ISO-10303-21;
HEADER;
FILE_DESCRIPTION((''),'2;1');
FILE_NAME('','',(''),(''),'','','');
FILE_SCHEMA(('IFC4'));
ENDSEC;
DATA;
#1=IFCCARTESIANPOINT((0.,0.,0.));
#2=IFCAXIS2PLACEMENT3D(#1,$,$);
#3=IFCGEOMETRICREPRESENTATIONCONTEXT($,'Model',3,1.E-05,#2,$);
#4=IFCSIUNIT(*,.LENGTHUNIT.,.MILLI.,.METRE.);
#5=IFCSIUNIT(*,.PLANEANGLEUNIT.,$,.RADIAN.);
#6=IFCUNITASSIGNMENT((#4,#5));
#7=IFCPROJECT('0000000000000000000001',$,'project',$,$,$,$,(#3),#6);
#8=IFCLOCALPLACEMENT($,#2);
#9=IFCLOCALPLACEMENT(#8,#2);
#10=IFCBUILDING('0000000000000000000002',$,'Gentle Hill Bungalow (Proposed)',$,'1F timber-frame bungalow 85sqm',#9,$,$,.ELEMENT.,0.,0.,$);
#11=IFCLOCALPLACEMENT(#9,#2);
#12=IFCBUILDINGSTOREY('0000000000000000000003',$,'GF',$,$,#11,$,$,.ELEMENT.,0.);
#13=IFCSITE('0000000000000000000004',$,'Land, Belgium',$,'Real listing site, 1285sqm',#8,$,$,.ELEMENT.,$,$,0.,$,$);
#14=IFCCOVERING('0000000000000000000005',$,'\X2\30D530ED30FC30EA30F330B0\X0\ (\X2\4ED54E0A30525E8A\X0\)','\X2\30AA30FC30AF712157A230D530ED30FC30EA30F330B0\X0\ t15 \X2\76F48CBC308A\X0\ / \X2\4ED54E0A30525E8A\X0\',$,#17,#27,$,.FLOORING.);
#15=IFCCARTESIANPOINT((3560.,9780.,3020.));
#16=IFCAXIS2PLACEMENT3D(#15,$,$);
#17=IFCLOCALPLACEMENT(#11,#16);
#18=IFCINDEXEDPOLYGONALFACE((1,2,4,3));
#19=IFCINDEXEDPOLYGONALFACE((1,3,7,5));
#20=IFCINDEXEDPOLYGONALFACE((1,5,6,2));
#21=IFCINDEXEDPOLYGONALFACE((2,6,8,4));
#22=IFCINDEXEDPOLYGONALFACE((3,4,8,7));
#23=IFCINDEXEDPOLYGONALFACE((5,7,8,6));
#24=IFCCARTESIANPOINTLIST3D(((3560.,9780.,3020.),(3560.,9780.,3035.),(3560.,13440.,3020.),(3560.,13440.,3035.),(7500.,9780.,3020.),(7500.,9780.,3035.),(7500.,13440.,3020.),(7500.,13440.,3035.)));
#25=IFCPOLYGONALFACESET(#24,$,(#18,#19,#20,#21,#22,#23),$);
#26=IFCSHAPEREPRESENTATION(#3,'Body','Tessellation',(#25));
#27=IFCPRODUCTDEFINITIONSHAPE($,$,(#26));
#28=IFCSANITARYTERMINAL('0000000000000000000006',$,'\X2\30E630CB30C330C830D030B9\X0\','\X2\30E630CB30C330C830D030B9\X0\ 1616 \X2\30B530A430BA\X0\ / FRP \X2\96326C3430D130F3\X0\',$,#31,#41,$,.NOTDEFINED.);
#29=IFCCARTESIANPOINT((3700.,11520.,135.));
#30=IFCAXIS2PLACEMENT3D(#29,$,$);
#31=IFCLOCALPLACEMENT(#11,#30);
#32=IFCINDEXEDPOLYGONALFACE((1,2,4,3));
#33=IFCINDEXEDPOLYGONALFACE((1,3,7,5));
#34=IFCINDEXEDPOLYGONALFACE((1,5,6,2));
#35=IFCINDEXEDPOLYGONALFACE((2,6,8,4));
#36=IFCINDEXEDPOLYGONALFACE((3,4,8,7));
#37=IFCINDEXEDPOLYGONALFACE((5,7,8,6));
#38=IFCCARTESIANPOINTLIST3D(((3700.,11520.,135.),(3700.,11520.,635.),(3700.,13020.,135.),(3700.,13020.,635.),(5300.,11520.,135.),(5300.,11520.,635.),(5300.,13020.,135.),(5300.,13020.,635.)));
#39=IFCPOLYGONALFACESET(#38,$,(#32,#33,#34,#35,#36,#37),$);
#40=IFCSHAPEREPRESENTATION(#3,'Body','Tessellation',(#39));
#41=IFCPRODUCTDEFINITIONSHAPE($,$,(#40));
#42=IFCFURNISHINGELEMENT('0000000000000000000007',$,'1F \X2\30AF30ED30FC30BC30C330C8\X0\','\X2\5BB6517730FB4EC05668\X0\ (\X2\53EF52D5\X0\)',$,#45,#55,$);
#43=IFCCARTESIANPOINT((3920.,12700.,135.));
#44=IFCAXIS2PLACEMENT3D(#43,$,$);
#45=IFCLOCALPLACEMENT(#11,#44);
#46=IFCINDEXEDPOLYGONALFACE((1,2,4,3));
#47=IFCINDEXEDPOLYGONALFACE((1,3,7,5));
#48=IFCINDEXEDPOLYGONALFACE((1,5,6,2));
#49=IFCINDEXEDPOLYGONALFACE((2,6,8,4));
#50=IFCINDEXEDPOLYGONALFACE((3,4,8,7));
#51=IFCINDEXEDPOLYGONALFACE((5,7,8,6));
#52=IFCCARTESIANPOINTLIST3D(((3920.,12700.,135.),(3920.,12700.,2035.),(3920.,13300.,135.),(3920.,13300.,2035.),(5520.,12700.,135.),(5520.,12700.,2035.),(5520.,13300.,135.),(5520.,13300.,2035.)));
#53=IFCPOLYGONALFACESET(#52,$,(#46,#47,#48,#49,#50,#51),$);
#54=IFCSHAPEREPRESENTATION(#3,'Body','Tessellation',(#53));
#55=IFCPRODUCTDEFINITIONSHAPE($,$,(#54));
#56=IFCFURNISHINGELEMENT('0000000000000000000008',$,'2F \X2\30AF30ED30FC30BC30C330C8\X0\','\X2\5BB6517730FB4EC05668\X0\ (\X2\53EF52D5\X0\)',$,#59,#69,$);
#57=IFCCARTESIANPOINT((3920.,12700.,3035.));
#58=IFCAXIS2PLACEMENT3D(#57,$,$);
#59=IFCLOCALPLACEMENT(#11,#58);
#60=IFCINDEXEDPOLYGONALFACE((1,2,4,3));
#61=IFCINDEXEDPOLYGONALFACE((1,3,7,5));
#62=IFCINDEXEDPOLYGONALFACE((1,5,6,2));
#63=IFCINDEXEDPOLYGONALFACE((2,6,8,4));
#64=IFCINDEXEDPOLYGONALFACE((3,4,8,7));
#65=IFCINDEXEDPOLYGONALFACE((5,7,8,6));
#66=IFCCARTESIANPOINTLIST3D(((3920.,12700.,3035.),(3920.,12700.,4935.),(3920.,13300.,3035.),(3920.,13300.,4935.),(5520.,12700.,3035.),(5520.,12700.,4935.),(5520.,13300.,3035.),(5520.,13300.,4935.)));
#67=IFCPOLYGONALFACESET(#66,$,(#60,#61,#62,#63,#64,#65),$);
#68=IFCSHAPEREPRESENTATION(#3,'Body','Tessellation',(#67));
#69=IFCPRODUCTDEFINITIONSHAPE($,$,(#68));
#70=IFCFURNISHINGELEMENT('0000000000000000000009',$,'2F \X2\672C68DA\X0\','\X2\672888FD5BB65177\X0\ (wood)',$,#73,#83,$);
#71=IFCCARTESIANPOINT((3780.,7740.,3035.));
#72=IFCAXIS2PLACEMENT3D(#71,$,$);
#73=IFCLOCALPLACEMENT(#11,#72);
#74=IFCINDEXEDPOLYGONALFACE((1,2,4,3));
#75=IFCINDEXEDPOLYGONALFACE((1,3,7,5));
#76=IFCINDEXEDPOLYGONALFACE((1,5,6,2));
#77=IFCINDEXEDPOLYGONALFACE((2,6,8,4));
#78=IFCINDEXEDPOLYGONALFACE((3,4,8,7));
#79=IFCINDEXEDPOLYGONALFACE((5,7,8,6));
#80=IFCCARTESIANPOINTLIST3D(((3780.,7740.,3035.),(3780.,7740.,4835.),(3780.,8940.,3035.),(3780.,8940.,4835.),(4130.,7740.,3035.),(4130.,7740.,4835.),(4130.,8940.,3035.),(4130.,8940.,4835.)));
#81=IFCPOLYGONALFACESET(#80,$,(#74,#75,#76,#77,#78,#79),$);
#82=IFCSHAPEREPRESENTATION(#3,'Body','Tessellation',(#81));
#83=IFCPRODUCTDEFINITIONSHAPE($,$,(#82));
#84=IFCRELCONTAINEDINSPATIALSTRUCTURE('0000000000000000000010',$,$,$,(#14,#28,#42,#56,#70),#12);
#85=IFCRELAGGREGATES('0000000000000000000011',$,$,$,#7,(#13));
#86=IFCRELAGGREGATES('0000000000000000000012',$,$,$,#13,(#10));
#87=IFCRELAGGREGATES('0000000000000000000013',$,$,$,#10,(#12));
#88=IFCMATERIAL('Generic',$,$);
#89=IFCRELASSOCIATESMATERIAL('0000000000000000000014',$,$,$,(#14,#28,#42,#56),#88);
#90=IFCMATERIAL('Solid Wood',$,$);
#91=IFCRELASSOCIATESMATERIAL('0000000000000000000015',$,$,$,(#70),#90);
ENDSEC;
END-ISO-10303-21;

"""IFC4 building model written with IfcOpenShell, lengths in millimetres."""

from ifc_helpers import new_model, si_unit, frame, frame_2d, origin, place, context, project, spatial, rectangle, extrude, material, element, save


model = new_model("IFC4")

# Units and contexts
model_context = context("Model", 3, precision=1e-05, world=origin())
ifc_project = project(units=[si_unit("LENGTHUNIT", "METRE", prefix="MILLI"), si_unit("PLANEANGLEUNIT", "RADIAN")], contexts=[model_context])

# Site, building, storey
site_placement = place(None, origin())
site = spatial("IfcSite", under=ifc_project, at=site_placement, Name="Land, Belgium", ObjectType="Real listing site, 1285sqm", CompositionType="ELEMENT", RefElevation=0.0)
building_placement = place(site_placement, origin())
building = spatial("IfcBuilding", under=site, at=building_placement, Name="Gentle Hill Bungalow (Proposed)", ObjectType="1F timber-frame bungalow 85sqm", CompositionType="ELEMENT", ElevationOfRefHeight=0.0, ElevationOfTerrain=0.0)
storey_placement = place(building_placement, origin())
storey = spatial("IfcBuildingStorey", under=building, at=storey_placement, Name="GF", CompositionType="ELEMENT", Elevation=0.0)

# Shared definitions
ifc_material_1 = material(Name="Solid Wood")

# Covering
ifc_material_2 = material(Name="Generic")
covering_1_placement = place(storey_placement, frame((3560.0, 9780.0, 3020.0)))
element("IfcCovering", 1, at=covering_1_placement, inside=storey, material=ifc_material_2, Name="フローリング (仕上げ床)", Description="オーク無垢フローリング t15 直貼り / 仕上げ床", PredefinedType="FLOORING", context=model_context, shape_type="SweptSolid", body=[
    extrude(rectangle(XDim=3940.0, YDim=3660.0, at=frame_2d((1970.0, 1830.0))), frame((3560.0, 9780.0, 3020.0)), (0.0, 0.0, 1.0), 15.0),
])

# Sanitary terminal
sanitary_terminal_placement = place(storey_placement, frame((3700.0, 11520.0, 135.0)))
element("IfcSanitaryTerminal", 2, at=sanitary_terminal_placement, inside=storey, material=ifc_material_2, Name="ユニットバス", Description="ユニットバス 1616 サイズ / FRP 防水パン", PredefinedType="NOTDEFINED", context=model_context, shape_type="SweptSolid", body=[
    extrude(rectangle(XDim=1600.0, YDim=1500.0, at=frame_2d((800.0, 750.0))), frame((3700.0, 11520.0, 135.0)), (0.0, 0.0, 1.0), 500.0),
])

# Furnishing elements
furnishing_1_placement = place(storey_placement, frame((3920.0, 12700.0, 135.0)))
element("IfcFurnishingElement", 3, at=furnishing_1_placement, inside=storey, material=ifc_material_2, Name="1F クローゼット", Description="家具・什器 (可動)", context=model_context, shape_type="SweptSolid", body=[
    extrude(rectangle(XDim=1600.0, YDim=600.0, at=frame_2d((800.0, 300.0))), frame((3920.0, 12700.0, 135.0)), (0.0, 0.0, 1.0), 1900.0),
])
furnishing_2_placement = place(storey_placement, frame((3920.0, 12700.0, 3035.0)))
element("IfcFurnishingElement", 4, at=furnishing_2_placement, inside=storey, material=ifc_material_2, Name="2F クローゼット", Description="家具・什器 (可動)", context=model_context, shape_type="SweptSolid", body=[
    extrude(rectangle(XDim=1600.0, YDim=600.0, at=frame_2d((800.0, 300.0))), frame((3920.0, 12700.0, 3035.0)), (0.0, 0.0, 1.0), 1900.0),
])
furnishing_3_placement = place(storey_placement, frame((3780.0, 7740.0, 3035.0)))
element("IfcFurnishingElement", 5, at=furnishing_3_placement, inside=storey, material=ifc_material_1, Name="2F 本棚", Description="木製家具 (wood)", context=model_context, shape_type="SweptSolid", body=[
    extrude(rectangle(XDim=350.0, YDim=1200.0, at=frame_2d((175.0, 600.0))), frame((3780.0, 7740.0, 3035.0)), (0.0, 0.0, 1.0), 1800.0),
])

save(model, "model.ifc")
